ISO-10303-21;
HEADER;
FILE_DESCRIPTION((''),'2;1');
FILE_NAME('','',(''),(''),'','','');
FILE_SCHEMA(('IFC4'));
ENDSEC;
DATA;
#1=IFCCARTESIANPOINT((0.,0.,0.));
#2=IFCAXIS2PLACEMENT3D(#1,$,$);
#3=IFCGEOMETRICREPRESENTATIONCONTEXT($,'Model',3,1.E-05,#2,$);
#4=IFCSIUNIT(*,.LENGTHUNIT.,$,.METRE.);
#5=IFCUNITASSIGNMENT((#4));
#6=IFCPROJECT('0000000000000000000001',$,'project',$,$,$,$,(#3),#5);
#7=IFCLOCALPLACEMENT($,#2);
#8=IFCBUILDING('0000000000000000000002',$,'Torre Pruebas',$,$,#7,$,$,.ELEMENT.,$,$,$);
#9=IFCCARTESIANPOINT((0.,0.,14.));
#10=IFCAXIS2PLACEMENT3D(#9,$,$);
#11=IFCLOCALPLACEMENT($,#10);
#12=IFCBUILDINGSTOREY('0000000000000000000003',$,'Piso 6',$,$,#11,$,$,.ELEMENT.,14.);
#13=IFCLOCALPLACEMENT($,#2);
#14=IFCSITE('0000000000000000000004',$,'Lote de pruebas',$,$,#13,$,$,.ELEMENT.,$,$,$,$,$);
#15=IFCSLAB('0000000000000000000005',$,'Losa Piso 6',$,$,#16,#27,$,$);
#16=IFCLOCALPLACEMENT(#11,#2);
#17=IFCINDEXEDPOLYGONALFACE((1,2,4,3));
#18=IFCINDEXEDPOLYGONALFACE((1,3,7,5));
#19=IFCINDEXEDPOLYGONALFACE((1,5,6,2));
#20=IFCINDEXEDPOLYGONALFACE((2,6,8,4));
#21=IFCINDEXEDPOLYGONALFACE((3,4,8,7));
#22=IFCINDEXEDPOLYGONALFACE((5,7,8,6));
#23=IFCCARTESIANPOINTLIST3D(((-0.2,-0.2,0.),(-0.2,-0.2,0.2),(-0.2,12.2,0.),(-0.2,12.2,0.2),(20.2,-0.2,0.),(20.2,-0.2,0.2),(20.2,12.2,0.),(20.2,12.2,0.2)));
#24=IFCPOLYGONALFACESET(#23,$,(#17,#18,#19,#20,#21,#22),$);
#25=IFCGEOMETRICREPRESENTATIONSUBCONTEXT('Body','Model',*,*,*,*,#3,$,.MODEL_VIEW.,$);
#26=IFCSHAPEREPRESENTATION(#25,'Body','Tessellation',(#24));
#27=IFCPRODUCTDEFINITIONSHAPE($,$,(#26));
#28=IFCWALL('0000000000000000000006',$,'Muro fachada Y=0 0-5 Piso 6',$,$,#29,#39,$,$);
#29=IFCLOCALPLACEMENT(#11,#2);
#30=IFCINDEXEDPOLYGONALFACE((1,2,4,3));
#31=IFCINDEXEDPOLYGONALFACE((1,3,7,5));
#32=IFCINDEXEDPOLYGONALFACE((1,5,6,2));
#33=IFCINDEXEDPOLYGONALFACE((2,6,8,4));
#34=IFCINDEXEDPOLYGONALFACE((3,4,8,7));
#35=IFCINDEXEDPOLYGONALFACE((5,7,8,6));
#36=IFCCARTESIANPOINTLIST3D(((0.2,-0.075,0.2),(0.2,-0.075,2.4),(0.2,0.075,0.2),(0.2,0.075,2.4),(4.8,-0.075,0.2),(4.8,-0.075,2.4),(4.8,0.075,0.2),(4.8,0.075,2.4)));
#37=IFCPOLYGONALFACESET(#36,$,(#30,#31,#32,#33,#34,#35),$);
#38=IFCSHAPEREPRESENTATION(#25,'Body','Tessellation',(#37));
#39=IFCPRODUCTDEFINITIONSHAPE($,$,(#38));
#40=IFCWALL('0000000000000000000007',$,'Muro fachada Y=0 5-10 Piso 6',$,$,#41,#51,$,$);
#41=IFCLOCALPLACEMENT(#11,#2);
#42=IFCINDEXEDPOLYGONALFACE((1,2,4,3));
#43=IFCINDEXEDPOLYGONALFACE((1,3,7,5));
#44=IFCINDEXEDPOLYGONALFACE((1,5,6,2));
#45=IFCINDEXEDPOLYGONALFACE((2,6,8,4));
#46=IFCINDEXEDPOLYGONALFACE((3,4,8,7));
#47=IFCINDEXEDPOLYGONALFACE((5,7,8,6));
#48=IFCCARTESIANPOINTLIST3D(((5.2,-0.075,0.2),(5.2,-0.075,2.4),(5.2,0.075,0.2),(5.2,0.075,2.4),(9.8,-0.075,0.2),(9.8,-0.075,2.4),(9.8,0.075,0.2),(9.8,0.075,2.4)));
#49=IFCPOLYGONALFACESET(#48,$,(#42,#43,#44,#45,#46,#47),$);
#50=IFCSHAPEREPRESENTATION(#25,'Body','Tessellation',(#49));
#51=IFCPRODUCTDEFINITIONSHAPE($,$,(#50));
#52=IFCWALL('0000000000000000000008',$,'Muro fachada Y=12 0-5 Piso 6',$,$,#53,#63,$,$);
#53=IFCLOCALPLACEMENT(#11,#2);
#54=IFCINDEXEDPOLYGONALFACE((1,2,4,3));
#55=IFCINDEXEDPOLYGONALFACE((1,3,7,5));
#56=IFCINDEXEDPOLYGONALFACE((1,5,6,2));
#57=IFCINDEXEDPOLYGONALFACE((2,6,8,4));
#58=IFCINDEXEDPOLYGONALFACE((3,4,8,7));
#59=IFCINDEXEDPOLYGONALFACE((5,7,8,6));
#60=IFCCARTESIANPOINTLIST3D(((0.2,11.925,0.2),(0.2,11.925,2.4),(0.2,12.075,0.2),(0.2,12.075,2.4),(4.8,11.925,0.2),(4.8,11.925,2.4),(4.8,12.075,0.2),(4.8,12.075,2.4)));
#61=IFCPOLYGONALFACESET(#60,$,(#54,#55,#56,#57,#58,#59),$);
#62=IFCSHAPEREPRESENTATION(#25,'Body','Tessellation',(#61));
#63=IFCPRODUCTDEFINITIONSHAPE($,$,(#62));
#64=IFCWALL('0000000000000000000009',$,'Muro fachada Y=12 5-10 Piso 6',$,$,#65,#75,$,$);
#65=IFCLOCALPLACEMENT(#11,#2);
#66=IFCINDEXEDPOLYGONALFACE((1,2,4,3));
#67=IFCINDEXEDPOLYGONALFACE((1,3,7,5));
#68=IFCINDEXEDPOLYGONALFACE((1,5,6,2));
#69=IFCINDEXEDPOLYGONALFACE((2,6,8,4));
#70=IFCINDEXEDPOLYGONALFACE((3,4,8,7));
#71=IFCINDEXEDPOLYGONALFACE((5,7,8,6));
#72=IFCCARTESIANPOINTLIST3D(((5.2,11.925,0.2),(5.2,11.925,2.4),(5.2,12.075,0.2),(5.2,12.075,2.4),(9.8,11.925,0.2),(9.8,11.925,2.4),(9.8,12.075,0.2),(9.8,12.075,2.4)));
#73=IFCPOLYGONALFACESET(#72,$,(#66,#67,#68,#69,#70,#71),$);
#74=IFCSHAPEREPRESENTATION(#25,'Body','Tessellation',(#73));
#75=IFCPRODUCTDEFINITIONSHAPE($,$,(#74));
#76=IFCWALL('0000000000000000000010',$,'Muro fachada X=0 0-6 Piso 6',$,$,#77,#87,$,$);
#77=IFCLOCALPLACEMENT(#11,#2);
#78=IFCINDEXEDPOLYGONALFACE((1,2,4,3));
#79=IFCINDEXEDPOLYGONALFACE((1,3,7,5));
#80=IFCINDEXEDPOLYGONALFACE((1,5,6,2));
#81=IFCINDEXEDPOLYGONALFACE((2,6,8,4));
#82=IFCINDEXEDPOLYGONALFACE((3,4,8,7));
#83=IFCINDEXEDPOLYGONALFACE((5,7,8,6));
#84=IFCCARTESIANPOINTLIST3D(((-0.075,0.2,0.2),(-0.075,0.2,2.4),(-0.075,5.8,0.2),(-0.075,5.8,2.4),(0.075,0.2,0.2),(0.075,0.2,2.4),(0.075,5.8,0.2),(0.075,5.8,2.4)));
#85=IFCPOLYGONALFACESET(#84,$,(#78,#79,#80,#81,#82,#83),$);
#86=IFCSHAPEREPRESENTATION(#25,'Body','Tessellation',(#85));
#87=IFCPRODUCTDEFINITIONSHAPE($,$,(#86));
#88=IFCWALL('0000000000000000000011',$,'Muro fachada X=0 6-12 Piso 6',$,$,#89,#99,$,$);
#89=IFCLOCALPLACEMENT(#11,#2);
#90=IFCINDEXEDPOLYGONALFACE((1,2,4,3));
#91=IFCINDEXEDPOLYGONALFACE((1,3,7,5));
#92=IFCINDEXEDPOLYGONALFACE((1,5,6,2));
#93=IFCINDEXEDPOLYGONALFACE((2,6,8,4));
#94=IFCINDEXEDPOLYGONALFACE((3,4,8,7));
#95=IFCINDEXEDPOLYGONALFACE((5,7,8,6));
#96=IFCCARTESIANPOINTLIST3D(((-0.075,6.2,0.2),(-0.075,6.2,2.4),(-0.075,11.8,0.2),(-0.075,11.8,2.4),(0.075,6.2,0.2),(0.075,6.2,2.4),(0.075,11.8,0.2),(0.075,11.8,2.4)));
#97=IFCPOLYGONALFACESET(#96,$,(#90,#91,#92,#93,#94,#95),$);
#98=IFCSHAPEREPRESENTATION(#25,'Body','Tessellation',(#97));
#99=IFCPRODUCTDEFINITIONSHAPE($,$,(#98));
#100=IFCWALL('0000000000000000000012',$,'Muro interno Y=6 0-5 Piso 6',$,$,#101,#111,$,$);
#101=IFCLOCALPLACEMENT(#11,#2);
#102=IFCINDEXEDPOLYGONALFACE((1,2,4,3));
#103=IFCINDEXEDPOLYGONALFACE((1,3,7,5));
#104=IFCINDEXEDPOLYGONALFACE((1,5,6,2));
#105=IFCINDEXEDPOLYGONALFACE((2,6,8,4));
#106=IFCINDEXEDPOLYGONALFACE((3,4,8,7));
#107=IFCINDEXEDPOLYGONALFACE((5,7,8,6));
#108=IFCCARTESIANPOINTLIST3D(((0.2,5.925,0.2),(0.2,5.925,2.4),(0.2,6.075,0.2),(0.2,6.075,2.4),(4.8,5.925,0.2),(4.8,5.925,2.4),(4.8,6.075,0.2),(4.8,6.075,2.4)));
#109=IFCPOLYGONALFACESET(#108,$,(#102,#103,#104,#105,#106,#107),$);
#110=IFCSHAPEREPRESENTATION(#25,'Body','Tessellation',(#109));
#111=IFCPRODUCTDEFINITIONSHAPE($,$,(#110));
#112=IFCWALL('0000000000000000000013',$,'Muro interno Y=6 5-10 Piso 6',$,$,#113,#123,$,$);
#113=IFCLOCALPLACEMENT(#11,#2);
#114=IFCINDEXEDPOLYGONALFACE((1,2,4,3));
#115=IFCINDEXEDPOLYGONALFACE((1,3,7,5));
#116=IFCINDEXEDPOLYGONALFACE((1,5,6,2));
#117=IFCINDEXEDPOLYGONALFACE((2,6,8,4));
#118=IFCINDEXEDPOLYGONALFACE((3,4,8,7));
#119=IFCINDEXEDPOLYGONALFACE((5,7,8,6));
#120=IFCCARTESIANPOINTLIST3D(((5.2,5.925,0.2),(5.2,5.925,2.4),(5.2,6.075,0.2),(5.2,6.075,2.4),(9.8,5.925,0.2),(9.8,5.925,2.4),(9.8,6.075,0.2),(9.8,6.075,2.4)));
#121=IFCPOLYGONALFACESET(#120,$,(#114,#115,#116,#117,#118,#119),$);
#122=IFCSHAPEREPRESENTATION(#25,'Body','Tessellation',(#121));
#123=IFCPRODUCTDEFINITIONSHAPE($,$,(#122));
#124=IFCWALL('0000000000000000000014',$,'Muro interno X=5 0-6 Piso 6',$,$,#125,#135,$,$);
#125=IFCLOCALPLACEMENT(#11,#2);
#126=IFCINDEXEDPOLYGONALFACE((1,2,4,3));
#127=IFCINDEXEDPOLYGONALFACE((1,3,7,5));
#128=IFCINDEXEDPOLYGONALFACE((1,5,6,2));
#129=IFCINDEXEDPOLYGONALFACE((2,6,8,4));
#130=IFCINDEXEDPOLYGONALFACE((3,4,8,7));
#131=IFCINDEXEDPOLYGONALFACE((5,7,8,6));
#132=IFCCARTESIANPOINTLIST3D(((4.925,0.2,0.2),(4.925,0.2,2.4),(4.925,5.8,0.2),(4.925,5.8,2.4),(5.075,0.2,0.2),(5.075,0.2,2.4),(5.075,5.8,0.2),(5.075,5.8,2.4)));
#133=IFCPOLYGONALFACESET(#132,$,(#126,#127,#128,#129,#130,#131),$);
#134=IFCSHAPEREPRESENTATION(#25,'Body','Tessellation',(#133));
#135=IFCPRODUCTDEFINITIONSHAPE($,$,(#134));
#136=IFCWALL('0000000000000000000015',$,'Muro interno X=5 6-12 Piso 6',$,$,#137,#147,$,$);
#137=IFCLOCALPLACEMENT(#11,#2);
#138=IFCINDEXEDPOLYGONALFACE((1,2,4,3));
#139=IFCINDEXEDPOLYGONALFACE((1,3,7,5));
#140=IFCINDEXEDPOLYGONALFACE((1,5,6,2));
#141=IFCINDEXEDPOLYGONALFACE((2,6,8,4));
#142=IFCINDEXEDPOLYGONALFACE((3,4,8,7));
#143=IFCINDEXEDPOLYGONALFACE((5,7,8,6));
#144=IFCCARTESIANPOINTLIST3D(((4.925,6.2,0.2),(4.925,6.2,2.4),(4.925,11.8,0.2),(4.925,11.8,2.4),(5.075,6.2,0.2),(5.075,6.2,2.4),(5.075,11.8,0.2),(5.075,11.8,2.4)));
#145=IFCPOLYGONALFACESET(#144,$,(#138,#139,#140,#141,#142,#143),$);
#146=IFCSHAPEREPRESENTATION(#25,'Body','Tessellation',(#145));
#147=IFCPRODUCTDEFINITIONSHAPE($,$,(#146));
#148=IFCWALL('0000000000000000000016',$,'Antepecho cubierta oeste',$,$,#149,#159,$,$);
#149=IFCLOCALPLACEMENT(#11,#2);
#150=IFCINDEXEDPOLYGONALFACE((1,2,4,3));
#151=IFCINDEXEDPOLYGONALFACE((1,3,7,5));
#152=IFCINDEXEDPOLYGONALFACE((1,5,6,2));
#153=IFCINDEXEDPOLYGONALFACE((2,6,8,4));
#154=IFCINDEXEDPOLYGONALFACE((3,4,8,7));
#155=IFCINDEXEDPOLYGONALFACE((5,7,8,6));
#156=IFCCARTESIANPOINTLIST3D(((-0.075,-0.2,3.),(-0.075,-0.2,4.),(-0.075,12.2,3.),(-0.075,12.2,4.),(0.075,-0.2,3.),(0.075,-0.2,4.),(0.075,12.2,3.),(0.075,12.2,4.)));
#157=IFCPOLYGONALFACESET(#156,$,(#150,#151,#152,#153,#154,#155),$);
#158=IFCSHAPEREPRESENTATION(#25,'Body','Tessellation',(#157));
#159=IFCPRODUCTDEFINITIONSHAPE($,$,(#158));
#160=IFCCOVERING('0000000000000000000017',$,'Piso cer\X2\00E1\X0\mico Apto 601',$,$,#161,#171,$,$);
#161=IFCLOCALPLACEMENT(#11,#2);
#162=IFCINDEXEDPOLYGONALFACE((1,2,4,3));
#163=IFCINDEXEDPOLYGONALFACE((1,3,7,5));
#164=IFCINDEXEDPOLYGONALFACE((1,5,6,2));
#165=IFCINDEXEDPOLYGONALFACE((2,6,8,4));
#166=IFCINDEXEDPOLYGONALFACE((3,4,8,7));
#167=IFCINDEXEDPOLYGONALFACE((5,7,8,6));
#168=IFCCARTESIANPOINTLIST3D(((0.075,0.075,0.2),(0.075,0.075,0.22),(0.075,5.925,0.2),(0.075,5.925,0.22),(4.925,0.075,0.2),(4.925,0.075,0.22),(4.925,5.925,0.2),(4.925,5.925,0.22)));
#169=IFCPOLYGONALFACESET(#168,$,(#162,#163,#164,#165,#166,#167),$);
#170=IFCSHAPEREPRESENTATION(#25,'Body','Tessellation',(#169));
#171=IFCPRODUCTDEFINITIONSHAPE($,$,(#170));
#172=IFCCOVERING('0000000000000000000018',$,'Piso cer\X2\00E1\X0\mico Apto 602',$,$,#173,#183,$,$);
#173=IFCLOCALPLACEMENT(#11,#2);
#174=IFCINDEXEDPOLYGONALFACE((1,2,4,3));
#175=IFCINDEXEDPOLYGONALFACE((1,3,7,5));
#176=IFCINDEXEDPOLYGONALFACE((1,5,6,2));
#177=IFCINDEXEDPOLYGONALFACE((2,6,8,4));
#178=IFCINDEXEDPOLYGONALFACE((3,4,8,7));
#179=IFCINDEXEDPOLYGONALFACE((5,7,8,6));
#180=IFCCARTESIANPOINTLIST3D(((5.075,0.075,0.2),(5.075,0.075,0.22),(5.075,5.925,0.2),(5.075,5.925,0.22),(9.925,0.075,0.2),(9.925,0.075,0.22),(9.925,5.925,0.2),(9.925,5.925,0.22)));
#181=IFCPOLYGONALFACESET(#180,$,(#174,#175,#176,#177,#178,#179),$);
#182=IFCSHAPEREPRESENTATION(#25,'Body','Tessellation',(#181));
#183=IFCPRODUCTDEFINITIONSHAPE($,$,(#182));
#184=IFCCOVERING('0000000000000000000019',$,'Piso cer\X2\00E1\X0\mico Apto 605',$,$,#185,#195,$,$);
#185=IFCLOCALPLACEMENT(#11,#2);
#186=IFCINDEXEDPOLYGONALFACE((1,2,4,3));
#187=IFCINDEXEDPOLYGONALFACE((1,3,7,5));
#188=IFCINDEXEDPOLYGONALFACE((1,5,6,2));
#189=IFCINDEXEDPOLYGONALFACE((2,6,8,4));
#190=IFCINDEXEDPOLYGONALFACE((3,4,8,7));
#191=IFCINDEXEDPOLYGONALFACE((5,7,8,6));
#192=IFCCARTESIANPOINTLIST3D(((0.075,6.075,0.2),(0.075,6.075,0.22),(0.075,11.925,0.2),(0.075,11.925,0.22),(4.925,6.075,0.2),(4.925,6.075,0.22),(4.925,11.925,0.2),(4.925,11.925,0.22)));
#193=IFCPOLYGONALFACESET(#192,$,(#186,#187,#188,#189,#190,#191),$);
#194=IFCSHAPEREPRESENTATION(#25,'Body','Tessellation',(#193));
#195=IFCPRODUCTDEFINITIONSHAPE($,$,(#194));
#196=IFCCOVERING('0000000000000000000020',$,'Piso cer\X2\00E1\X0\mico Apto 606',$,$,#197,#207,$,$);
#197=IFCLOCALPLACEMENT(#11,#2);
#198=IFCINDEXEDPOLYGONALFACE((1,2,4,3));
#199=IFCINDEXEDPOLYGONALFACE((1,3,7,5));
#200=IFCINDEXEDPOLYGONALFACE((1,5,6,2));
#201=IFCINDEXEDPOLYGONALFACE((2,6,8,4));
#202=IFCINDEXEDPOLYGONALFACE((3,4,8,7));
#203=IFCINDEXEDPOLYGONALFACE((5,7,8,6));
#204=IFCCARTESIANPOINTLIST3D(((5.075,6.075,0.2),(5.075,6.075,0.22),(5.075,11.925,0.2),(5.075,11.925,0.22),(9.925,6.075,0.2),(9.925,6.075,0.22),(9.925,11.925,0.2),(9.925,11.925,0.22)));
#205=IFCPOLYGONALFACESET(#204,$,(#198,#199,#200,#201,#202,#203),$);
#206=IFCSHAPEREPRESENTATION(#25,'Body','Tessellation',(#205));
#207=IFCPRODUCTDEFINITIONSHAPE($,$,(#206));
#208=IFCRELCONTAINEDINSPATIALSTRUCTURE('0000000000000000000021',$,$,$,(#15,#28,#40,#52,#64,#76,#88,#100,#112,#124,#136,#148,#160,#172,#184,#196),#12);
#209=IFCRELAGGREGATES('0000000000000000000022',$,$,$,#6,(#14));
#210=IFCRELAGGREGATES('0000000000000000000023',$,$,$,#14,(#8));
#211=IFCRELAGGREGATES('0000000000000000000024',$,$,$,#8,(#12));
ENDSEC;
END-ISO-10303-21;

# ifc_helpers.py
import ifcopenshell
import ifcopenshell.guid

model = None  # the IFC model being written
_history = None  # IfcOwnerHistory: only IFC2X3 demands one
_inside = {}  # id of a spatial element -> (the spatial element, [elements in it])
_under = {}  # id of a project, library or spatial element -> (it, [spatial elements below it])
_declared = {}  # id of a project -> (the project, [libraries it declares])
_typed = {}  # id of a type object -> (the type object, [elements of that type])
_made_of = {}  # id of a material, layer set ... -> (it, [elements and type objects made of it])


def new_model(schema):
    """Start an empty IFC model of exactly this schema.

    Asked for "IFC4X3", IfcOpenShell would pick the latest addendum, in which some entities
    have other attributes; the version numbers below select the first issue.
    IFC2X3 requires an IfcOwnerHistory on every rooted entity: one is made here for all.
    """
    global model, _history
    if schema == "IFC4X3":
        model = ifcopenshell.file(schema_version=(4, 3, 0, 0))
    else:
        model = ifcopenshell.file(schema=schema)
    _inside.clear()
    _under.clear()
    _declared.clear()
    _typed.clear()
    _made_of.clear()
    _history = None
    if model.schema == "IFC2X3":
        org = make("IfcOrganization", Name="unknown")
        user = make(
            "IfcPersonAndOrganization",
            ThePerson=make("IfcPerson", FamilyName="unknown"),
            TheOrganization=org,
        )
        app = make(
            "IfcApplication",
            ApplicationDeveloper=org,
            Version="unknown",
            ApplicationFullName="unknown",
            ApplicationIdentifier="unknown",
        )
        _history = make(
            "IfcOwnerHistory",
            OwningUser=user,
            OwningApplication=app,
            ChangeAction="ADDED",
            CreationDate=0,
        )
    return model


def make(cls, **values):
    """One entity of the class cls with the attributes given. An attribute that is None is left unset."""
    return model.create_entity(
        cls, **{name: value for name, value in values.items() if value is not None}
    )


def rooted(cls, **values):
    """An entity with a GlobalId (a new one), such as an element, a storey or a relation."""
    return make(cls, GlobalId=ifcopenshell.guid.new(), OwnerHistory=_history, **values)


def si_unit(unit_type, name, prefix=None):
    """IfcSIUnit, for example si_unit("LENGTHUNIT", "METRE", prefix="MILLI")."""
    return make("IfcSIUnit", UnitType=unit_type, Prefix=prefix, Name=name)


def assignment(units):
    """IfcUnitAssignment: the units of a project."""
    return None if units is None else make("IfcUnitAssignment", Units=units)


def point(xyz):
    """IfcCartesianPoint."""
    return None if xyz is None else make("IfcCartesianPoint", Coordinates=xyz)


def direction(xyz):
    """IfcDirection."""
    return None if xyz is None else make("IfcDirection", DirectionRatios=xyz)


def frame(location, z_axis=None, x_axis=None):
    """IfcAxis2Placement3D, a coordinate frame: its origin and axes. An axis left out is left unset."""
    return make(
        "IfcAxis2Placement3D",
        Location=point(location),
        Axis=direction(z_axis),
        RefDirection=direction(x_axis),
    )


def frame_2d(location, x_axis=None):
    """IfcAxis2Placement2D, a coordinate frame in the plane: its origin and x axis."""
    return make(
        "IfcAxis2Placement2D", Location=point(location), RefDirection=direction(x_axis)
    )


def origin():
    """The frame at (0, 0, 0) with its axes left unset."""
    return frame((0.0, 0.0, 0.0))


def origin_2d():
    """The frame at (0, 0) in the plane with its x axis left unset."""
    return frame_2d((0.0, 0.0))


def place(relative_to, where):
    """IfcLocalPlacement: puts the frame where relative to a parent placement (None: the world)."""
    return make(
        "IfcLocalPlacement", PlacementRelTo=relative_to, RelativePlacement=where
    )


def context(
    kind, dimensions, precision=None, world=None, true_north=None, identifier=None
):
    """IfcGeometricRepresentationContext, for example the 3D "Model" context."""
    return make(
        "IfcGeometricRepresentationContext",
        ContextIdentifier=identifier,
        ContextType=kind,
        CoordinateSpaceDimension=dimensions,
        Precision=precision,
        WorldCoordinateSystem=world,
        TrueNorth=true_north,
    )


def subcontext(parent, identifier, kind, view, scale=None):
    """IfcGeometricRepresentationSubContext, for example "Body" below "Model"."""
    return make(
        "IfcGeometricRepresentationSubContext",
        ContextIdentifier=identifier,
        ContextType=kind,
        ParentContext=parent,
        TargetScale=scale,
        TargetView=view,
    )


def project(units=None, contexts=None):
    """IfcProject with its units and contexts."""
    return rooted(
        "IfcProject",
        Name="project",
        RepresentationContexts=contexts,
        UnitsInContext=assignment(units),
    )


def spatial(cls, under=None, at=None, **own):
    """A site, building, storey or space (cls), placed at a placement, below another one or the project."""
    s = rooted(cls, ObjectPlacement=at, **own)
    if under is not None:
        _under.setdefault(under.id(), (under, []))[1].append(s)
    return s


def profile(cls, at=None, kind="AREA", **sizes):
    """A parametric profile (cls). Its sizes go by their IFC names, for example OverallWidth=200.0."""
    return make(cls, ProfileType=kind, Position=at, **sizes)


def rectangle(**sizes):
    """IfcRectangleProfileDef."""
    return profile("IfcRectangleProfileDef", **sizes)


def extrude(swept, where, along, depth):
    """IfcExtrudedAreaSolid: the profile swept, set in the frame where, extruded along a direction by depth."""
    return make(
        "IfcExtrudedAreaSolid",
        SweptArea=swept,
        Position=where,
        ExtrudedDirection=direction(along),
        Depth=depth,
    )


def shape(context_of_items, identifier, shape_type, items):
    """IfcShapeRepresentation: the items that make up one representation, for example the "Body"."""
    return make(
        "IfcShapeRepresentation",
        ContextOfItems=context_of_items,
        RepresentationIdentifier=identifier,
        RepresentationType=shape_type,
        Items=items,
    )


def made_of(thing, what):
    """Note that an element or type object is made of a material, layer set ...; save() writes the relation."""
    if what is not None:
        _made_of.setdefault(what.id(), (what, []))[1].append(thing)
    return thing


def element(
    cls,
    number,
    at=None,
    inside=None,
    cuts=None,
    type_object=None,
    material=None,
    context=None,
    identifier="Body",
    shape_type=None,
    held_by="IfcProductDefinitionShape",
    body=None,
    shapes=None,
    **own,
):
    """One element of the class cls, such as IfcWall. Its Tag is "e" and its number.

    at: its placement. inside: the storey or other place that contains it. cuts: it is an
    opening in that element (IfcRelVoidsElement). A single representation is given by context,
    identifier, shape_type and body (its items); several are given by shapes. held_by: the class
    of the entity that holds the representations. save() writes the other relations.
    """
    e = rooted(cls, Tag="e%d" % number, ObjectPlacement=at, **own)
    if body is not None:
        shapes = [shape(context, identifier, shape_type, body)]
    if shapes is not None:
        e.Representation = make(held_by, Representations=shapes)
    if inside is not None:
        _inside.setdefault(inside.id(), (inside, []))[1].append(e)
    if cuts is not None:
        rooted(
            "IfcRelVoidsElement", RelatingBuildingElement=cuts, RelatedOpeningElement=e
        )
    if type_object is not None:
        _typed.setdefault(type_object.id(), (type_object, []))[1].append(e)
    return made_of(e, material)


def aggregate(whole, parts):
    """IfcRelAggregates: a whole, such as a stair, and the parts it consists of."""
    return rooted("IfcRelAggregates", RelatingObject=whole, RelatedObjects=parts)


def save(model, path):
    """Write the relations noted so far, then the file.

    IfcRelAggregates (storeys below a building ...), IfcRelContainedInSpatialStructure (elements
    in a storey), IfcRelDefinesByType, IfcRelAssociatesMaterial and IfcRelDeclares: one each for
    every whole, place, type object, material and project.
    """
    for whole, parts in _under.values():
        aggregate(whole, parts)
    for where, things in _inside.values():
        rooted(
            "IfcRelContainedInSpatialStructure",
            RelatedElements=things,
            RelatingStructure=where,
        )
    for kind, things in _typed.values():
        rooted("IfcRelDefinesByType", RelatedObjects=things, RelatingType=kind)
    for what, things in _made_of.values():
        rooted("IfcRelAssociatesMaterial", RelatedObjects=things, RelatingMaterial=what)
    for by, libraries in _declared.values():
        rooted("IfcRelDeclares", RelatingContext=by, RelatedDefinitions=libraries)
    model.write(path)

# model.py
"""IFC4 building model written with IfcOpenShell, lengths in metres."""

from ifc_helpers import new_model, si_unit, frame, origin, origin_2d, place, context, subcontext, project, spatial, rectangle, extrude, element, save


model = new_model("IFC4")

# Units and contexts
model_context = context("Model", 3, precision=1e-05, world=origin())
body_context = subcontext(model_context, "Body", "Model", "MODEL_VIEW")
ifc_project = project(units=[si_unit("LENGTHUNIT", "METRE")], contexts=[model_context])

# Site, building, storey
site_placement = place(None, origin())
site = spatial("IfcSite", under=ifc_project, at=site_placement, Name="Lote de pruebas", CompositionType="ELEMENT")
building_placement = place(None, origin())
building = spatial("IfcBuilding", under=site, at=building_placement, Name="Torre Pruebas", CompositionType="ELEMENT")
storey_placement = place(None, frame((0.0, 0.0, 14.0)))
storey = spatial("IfcBuildingStorey", under=building, at=storey_placement, Name="Piso 6", CompositionType="ELEMENT", Elevation=14.0)

# Slab
slab_placement = place(None, frame((10.0, 6.0, 14.0)))
element("IfcSlab", 1, at=slab_placement, inside=storey, Name="Losa Piso 6", context=body_context, shape_type="SweptSolid", body=[
    extrude(rectangle(XDim=20.4, YDim=12.4, at=origin_2d()), origin(), (0.0, 0.0, 1.0), 0.2),
])

# Walls
for number, where, name in (
    (2, (2.5, 0.0, 14.2), "Muro fachada Y=0 0-5 Piso 6"),
    (3, (7.5, 0.0, 14.2), "Muro fachada Y=0 5-10 Piso 6"),
    (4, (2.5, 12.0, 14.2), "Muro fachada Y=12 0-5 Piso 6"),
    (5, (7.5, 12.0, 14.2), "Muro fachada Y=12 5-10 Piso 6"),
):
    element("IfcWall", number, at=place(None, frame(where)), inside=storey, Name=name, context=body_context, shape_type="SweptSolid", body=[
        extrude(rectangle(XDim=4.6, YDim=0.15, at=origin_2d()), origin(), (0.0, 0.0, 1.0), 2.2),
    ])
for number, where, name in (
    (6, (0.0, 3.0, 14.2), "Muro fachada X=0 0-6 Piso 6"),
    (7, (0.0, 9.0, 14.2), "Muro fachada X=0 6-12 Piso 6"),
):
    element("IfcWall", number, at=place(None, frame(where)), inside=storey, Name=name, context=body_context, shape_type="SweptSolid", body=[
        extrude(rectangle(XDim=0.15, YDim=5.6, at=origin_2d()), origin(), (0.0, 0.0, 1.0), 2.2),
    ])
for number, where, name in (
    (8, (2.5, 6.0, 14.2), "Muro interno Y=6 0-5 Piso 6"),
    (9, (7.5, 6.0, 14.2), "Muro interno Y=6 5-10 Piso 6"),
):
    element("IfcWall", number, at=place(None, frame(where)), inside=storey, Name=name, context=body_context, shape_type="SweptSolid", body=[
        extrude(rectangle(XDim=4.6, YDim=0.15, at=origin_2d()), origin(), (0.0, 0.0, 1.0), 2.2),
    ])
for number, where, name in (
    (10, (5.0, 3.0, 14.2), "Muro interno X=5 0-6 Piso 6"),
    (11, (5.0, 9.0, 14.2), "Muro interno X=5 6-12 Piso 6"),
):
    element("IfcWall", number, at=place(None, frame(where)), inside=storey, Name=name, context=body_context, shape_type="SweptSolid", body=[
        extrude(rectangle(XDim=0.15, YDim=5.6, at=origin_2d()), origin(), (0.0, 0.0, 1.0), 2.2),
    ])
wall_placement = place(None, frame((0.0, 6.0, 17.0)))
element("IfcWall", 12, at=wall_placement, inside=storey, Name="Antepecho cubierta oeste", context=body_context, shape_type="SweptSolid", body=[
    extrude(rectangle(XDim=0.15, YDim=12.4, at=origin_2d()), origin(), (0.0, 0.0, 1.0), 1.0),
])

# Coverings
for number, where, name in (
    (13, (2.5, 3.0, 14.2), "Piso cerámico Apto 601"),
    (14, (7.5, 3.0, 14.2), "Piso cerámico Apto 602"),
    (15, (2.5, 9.0, 14.2), "Piso cerámico Apto 605"),
    (16, (7.5, 9.0, 14.2), "Piso cerámico Apto 606"),
):
    element("IfcCovering", number, at=place(None, frame(where)), inside=storey, Name=name, context=body_context, shape_type="SweptSolid", body=[
        extrude(rectangle(XDim=4.85, YDim=5.85, at=origin_2d()), origin(), (0.0, 0.0, 1.0), 0.02),
    ])

save(model, "model.ifc")
